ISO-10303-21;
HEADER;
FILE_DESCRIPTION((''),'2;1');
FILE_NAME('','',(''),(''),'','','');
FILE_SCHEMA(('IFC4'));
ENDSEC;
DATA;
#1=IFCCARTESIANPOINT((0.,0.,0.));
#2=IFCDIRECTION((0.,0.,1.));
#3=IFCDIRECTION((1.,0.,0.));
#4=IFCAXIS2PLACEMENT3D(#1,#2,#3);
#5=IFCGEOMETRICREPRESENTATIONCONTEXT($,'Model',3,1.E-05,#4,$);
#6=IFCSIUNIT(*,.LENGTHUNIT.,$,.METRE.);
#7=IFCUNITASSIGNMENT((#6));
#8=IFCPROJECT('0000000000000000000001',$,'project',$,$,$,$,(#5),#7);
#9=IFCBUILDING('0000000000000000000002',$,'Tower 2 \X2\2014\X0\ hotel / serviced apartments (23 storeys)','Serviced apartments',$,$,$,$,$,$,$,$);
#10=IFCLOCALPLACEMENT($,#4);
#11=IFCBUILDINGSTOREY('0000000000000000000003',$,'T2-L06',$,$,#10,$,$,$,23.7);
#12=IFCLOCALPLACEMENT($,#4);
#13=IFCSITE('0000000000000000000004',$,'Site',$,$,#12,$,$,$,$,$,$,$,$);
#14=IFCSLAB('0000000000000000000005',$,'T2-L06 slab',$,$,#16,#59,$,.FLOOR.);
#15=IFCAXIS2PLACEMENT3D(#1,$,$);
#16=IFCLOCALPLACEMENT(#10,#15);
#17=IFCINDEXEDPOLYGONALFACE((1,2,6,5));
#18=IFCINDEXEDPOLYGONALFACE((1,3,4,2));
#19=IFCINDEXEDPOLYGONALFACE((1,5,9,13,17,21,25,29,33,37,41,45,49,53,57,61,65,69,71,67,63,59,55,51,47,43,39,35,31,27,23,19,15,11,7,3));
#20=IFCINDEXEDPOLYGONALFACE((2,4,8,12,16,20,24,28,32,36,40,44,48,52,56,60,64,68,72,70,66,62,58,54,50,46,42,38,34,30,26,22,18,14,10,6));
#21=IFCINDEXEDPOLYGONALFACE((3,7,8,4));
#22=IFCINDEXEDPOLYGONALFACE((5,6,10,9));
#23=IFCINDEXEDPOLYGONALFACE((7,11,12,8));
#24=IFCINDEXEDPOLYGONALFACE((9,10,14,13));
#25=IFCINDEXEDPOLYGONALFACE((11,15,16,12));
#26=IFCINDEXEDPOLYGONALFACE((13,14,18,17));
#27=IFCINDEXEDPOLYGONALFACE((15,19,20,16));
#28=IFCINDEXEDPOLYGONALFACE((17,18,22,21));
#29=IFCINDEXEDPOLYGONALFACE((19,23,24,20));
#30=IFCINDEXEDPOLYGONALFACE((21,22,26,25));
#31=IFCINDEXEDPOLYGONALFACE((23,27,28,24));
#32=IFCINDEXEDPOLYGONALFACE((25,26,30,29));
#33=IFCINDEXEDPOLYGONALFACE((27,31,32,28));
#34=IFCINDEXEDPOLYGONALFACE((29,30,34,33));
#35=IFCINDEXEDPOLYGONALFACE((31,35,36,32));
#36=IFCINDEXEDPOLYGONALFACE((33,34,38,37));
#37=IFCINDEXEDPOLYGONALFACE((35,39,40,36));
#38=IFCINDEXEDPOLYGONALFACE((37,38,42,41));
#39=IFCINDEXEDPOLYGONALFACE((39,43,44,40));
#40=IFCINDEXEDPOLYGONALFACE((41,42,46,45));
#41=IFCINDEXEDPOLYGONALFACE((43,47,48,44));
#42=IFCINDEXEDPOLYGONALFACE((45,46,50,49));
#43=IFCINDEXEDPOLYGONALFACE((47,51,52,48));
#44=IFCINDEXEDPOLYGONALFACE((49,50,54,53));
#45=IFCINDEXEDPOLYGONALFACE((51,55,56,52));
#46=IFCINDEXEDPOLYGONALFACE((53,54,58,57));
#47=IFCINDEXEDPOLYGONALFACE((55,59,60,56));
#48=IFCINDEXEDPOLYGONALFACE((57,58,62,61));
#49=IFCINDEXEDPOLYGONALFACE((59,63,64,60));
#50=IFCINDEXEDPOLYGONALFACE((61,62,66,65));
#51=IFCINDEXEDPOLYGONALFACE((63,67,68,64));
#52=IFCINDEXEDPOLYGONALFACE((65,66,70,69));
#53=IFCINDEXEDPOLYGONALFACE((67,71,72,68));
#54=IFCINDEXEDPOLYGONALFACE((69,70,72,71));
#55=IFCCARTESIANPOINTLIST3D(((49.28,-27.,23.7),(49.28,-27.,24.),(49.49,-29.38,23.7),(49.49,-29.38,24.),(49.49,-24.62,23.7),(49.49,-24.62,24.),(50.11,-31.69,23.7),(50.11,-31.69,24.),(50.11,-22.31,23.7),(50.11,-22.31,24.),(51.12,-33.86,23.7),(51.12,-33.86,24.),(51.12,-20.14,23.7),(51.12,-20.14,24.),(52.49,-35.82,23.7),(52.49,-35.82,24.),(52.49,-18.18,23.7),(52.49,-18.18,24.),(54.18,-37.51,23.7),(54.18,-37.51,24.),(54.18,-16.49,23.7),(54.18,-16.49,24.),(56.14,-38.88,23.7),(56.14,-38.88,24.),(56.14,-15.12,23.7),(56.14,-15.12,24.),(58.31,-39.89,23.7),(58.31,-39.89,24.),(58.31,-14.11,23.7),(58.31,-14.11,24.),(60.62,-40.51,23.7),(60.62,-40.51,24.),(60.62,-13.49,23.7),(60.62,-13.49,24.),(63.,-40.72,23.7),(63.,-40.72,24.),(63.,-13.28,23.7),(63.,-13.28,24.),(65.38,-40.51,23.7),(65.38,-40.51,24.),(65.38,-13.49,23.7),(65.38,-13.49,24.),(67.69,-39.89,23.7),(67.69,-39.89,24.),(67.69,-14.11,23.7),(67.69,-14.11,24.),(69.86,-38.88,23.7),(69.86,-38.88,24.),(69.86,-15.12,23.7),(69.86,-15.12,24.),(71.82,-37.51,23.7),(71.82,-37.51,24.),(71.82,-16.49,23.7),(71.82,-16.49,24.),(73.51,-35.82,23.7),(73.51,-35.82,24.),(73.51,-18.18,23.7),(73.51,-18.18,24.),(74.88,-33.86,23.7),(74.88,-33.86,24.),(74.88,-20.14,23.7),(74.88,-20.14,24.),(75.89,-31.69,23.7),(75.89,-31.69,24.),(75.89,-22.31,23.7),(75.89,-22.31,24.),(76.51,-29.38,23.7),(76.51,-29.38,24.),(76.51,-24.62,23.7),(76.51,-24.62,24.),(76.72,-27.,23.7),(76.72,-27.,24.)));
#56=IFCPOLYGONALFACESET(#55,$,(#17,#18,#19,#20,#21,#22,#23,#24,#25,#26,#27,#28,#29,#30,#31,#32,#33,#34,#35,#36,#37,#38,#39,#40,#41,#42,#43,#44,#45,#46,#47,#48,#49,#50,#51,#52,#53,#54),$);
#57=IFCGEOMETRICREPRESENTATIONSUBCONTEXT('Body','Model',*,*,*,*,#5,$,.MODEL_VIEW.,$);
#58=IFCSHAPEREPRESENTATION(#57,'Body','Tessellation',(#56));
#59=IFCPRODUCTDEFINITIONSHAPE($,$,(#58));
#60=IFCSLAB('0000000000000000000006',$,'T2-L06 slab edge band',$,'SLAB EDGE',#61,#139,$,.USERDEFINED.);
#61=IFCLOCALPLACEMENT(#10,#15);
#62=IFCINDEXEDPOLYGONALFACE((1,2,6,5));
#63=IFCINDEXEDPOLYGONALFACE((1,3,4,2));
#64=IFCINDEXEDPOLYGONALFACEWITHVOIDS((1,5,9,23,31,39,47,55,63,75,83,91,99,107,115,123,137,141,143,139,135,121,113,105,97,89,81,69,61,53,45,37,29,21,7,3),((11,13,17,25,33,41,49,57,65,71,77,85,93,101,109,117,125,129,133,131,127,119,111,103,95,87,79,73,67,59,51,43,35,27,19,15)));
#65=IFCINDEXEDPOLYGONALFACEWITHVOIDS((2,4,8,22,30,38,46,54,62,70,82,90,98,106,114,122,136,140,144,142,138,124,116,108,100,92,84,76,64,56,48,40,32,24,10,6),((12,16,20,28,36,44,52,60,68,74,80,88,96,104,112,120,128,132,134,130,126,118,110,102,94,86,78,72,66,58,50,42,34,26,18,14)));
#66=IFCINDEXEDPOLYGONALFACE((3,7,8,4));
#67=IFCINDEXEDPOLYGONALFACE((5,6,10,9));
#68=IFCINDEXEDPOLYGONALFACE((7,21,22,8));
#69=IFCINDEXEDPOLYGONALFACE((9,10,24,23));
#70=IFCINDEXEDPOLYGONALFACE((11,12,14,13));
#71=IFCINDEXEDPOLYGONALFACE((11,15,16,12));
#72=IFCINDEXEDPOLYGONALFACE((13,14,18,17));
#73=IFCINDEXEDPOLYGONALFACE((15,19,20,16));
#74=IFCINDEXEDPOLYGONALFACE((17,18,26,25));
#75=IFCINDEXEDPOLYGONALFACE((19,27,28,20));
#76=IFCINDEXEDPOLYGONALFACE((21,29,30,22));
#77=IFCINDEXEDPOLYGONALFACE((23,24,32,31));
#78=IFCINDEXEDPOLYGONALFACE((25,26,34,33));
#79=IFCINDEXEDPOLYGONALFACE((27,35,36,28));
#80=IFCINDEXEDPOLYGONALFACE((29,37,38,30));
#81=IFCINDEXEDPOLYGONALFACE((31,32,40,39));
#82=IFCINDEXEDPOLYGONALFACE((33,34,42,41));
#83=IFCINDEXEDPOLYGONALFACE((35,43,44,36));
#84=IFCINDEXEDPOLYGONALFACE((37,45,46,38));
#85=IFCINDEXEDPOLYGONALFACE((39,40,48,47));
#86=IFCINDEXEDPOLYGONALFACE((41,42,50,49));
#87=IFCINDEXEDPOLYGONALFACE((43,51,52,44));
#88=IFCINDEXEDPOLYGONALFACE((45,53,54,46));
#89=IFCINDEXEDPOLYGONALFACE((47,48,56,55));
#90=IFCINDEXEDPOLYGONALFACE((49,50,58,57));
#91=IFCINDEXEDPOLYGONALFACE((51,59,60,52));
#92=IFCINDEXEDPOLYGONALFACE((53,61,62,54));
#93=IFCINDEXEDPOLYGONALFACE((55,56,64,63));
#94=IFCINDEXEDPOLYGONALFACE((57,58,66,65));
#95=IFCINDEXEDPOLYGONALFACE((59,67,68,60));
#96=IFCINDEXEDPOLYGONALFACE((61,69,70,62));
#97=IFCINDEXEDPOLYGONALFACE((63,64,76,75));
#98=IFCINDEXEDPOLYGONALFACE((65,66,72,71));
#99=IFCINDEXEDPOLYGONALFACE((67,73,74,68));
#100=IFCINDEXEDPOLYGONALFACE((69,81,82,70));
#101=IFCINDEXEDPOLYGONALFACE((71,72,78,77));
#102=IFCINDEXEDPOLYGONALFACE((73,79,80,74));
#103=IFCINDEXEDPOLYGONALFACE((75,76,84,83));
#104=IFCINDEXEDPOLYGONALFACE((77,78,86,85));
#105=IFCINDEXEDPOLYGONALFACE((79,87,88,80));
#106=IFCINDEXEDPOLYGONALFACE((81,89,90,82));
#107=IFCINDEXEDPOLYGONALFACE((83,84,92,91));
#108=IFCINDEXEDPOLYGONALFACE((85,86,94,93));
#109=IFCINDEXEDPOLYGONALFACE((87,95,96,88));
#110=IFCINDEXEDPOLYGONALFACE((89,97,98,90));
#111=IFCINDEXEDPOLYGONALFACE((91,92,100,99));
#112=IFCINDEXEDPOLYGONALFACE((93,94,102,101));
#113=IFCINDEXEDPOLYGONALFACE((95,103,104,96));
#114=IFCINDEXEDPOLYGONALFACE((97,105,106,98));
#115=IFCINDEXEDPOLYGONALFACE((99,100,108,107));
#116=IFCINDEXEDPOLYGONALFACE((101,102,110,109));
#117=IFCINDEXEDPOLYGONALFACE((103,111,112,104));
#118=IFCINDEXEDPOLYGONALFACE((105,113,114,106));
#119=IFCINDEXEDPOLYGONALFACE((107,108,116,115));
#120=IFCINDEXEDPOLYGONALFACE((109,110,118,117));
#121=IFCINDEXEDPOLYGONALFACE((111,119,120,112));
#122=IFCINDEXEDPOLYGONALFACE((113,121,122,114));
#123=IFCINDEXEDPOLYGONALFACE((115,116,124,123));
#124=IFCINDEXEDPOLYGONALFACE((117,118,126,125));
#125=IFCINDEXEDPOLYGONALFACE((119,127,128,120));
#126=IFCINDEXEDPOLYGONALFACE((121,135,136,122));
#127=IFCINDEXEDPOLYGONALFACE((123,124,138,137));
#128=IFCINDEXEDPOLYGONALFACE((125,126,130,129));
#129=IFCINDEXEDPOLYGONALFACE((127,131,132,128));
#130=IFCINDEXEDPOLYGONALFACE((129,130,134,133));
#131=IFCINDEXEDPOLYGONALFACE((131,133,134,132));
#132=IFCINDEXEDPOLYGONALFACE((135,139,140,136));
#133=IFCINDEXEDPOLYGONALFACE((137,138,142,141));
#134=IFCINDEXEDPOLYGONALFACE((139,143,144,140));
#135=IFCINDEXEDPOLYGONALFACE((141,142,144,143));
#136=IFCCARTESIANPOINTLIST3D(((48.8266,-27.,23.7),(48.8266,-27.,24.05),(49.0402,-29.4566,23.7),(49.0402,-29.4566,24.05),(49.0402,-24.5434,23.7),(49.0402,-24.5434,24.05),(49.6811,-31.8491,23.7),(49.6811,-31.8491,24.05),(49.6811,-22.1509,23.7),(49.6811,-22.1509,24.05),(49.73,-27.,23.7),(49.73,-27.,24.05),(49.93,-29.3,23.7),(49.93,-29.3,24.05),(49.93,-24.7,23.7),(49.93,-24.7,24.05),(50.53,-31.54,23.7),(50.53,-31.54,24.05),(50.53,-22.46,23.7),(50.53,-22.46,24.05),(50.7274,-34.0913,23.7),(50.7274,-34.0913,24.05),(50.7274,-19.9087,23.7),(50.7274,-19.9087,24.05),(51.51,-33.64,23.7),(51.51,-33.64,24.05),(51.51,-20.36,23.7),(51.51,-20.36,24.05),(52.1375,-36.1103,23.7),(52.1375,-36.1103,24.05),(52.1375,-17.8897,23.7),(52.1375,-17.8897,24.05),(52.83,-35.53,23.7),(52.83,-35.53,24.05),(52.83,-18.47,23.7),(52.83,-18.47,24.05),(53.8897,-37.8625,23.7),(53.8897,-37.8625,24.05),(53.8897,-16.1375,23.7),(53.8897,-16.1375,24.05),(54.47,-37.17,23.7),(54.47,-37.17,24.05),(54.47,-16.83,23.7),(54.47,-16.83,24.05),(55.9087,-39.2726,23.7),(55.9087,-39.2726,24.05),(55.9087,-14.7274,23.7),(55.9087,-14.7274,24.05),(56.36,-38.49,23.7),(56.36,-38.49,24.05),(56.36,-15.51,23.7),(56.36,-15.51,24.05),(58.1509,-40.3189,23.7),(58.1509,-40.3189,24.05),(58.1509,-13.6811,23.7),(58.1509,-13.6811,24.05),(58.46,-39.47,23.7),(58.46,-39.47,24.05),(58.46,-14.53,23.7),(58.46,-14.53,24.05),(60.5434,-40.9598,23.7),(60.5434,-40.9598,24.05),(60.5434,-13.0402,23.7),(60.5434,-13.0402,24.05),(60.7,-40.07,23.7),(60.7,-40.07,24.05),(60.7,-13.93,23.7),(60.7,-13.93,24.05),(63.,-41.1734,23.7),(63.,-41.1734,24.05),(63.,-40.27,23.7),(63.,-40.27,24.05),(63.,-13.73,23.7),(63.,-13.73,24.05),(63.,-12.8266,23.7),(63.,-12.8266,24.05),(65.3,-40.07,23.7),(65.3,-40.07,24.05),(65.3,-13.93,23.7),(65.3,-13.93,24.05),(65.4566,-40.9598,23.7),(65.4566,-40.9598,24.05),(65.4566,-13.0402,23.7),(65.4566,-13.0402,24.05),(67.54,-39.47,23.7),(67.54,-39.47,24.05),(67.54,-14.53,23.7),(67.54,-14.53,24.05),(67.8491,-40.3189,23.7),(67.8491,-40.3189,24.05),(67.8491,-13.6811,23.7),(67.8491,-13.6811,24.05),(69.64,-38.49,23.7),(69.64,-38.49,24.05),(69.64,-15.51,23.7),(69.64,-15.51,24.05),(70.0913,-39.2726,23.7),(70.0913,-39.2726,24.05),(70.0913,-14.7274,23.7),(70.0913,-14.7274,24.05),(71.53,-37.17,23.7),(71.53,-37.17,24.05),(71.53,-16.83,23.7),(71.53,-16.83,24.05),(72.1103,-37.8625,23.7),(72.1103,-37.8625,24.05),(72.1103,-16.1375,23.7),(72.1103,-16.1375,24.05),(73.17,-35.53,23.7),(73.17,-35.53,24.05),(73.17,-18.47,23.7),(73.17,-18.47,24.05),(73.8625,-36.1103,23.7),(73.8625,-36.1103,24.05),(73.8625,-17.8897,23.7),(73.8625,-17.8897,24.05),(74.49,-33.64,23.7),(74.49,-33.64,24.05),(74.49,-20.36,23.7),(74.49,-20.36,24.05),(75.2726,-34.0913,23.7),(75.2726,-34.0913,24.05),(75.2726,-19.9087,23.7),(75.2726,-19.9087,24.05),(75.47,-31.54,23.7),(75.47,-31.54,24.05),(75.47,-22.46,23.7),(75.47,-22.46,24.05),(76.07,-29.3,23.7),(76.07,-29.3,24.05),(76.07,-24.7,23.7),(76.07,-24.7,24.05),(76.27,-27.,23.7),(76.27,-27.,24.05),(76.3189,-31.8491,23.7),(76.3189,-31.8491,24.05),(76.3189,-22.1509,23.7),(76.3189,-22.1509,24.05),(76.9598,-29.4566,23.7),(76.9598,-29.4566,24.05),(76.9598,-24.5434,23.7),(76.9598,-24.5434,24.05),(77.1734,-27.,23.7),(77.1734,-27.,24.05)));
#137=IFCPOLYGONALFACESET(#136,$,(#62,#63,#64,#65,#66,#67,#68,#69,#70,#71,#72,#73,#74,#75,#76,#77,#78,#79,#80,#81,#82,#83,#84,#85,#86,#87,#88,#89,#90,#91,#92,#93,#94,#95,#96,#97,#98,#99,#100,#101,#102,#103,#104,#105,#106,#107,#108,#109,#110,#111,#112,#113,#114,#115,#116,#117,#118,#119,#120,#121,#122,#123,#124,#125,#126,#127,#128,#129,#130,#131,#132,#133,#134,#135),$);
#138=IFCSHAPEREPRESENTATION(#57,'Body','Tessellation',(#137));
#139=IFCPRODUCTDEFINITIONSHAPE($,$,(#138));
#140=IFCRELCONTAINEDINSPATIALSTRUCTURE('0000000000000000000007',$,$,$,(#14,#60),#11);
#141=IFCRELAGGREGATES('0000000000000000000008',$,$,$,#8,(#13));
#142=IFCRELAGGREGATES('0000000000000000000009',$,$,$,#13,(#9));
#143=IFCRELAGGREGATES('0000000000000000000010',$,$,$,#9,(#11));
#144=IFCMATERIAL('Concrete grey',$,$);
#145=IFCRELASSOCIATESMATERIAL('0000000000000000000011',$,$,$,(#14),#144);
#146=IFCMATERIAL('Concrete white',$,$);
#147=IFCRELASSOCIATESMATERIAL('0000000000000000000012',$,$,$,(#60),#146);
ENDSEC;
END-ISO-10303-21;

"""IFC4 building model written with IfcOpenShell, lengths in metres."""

from ifc_helpers import new_model, si_unit, frame, origin_with_axes, place, context, subcontext, project, spatial, polyline, outline, extrude, material, element, save


model = new_model("IFC4")

# Units and contexts
model_context = context("Model", 3, precision=1e-05, world=origin_with_axes())
body_context = subcontext(model_context, "Body", "Model", "MODEL_VIEW")
ifc_project = project(units=[si_unit("LENGTHUNIT", "METRE")], contexts=[model_context])

# Site, building, storey
site_placement = place(None, origin_with_axes())
site = spatial("IfcSite", under=ifc_project, at=site_placement, Name="Site")
building = spatial("IfcBuilding", under=site, Name="Tower 2 — hotel / serviced apartments (23 storeys)", Description="Serviced apartments")
storey_placement = place(None, origin_with_axes())
storey = spatial("IfcBuildingStorey", under=building, at=storey_placement, Name="T2-L06", Elevation=23.7)

# Slab
ifc_material_1 = material(Name="Concrete grey")
slab_1_placement = place(storey_placement, origin_with_axes())
element("IfcSlab", 1, at=slab_1_placement, inside=storey, material=ifc_material_1, Name="T2-L06 slab", PredefinedType="FLOOR", context=body_context, shape_type="SweptSolid", body=[
    extrude(outline(polyline([(76.51, -29.38), (76.72, -27.0), (76.51, -24.62), (75.89, -22.31), (74.88, -20.14), (73.51, -18.18), (71.82, -16.49), (69.86, -15.12), (67.69, -14.11), (65.38, -13.49), (63.0, -13.28), (60.62, -13.49), (58.31, -14.11), (56.14, -15.12), (54.18, -16.49), (52.49, -18.18), (51.12, -20.14), (50.11, -22.31), (49.49, -24.62), (49.28, -27.0), (49.49, -29.38), (50.11, -31.69), (51.12, -33.86), (52.49, -35.82), (54.18, -37.51), (56.14, -38.88), (58.31, -39.89), (60.62, -40.51), (63.0, -40.72), (65.38, -40.51), (67.69, -39.89), (69.86, -38.88), (71.82, -37.51), (73.51, -35.82), (74.88, -33.86), (75.89, -31.69), (76.51, -29.38)])), frame((0.0, 0.0, 23.7), z_axis=(0.0, 0.0, 1.0), x_axis=(1.0, 0.0, 0.0)), (0.0, 0.0, 1.0), 0.3),
])

# Slab
ifc_material_2 = material(Name="Concrete white")
slab_2_placement = place(storey_placement, origin_with_axes())
element("IfcSlab", 2, at=slab_2_placement, inside=storey, material=ifc_material_2, Name="T2-L06 slab edge band", ObjectType="SLAB EDGE", PredefinedType="USERDEFINED", context=body_context, shape_type="SweptSolid", body=[
    extrude(outline(polyline([(77.1734, -27.0), (76.9598, -24.5434), (76.3189, -22.1509), (75.2726, -19.9087), (73.8625, -17.8897), (72.1103, -16.1375), (70.0913, -14.7274), (67.8491, -13.6811), (65.4566, -13.0402), (63.0, -12.8266), (60.5434, -13.0402), (58.1509, -13.6811), (55.9087, -14.7274), (53.8897, -16.1375), (52.1375, -17.8897), (50.7274, -19.9087), (49.6811, -22.1509), (49.0402, -24.5434), (48.8266, -27.0), (49.0402, -29.4566), (49.6811, -31.8491), (50.7274, -34.0913), (52.1375, -36.1103), (53.8897, -37.8625), (55.9087, -39.2726), (58.1509, -40.3189), (60.5434, -40.9598), (63.0, -41.1734), (65.4566, -40.9598), (67.8491, -40.3189), (70.0913, -39.2726), (72.1103, -37.8625), (73.8625, -36.1103), (75.2726, -34.0913), (76.3189, -31.8491), (76.9598, -29.4566), (77.1734, -27.0)]), holes=[polyline([(76.27, -27.0), (76.07, -24.7), (75.47, -22.46), (74.49, -20.36), (73.17, -18.47), (71.53, -16.83), (69.64, -15.51), (67.54, -14.53), (65.3, -13.93), (63.0, -13.73), (60.7, -13.93), (58.46, -14.53), (56.36, -15.51), (54.47, -16.83), (52.83, -18.47), (51.51, -20.36), (50.53, -22.46), (49.93, -24.7), (49.73, -27.0), (49.93, -29.3), (50.53, -31.54), (51.51, -33.64), (52.83, -35.53), (54.47, -37.17), (56.36, -38.49), (58.46, -39.47), (60.7, -40.07), (63.0, -40.27), (65.3, -40.07), (67.54, -39.47), (69.64, -38.49), (71.53, -37.17), (73.17, -35.53), (74.49, -33.64), (75.47, -31.54), (76.07, -29.3), (76.27, -27.0)])]), frame((0.0, 0.0, 23.7), z_axis=(0.0, 0.0, 1.0), x_axis=(1.0, 0.0, 0.0)), (0.0, 0.0, 1.0), 0.35),
])

save(model, "model.ifc")
